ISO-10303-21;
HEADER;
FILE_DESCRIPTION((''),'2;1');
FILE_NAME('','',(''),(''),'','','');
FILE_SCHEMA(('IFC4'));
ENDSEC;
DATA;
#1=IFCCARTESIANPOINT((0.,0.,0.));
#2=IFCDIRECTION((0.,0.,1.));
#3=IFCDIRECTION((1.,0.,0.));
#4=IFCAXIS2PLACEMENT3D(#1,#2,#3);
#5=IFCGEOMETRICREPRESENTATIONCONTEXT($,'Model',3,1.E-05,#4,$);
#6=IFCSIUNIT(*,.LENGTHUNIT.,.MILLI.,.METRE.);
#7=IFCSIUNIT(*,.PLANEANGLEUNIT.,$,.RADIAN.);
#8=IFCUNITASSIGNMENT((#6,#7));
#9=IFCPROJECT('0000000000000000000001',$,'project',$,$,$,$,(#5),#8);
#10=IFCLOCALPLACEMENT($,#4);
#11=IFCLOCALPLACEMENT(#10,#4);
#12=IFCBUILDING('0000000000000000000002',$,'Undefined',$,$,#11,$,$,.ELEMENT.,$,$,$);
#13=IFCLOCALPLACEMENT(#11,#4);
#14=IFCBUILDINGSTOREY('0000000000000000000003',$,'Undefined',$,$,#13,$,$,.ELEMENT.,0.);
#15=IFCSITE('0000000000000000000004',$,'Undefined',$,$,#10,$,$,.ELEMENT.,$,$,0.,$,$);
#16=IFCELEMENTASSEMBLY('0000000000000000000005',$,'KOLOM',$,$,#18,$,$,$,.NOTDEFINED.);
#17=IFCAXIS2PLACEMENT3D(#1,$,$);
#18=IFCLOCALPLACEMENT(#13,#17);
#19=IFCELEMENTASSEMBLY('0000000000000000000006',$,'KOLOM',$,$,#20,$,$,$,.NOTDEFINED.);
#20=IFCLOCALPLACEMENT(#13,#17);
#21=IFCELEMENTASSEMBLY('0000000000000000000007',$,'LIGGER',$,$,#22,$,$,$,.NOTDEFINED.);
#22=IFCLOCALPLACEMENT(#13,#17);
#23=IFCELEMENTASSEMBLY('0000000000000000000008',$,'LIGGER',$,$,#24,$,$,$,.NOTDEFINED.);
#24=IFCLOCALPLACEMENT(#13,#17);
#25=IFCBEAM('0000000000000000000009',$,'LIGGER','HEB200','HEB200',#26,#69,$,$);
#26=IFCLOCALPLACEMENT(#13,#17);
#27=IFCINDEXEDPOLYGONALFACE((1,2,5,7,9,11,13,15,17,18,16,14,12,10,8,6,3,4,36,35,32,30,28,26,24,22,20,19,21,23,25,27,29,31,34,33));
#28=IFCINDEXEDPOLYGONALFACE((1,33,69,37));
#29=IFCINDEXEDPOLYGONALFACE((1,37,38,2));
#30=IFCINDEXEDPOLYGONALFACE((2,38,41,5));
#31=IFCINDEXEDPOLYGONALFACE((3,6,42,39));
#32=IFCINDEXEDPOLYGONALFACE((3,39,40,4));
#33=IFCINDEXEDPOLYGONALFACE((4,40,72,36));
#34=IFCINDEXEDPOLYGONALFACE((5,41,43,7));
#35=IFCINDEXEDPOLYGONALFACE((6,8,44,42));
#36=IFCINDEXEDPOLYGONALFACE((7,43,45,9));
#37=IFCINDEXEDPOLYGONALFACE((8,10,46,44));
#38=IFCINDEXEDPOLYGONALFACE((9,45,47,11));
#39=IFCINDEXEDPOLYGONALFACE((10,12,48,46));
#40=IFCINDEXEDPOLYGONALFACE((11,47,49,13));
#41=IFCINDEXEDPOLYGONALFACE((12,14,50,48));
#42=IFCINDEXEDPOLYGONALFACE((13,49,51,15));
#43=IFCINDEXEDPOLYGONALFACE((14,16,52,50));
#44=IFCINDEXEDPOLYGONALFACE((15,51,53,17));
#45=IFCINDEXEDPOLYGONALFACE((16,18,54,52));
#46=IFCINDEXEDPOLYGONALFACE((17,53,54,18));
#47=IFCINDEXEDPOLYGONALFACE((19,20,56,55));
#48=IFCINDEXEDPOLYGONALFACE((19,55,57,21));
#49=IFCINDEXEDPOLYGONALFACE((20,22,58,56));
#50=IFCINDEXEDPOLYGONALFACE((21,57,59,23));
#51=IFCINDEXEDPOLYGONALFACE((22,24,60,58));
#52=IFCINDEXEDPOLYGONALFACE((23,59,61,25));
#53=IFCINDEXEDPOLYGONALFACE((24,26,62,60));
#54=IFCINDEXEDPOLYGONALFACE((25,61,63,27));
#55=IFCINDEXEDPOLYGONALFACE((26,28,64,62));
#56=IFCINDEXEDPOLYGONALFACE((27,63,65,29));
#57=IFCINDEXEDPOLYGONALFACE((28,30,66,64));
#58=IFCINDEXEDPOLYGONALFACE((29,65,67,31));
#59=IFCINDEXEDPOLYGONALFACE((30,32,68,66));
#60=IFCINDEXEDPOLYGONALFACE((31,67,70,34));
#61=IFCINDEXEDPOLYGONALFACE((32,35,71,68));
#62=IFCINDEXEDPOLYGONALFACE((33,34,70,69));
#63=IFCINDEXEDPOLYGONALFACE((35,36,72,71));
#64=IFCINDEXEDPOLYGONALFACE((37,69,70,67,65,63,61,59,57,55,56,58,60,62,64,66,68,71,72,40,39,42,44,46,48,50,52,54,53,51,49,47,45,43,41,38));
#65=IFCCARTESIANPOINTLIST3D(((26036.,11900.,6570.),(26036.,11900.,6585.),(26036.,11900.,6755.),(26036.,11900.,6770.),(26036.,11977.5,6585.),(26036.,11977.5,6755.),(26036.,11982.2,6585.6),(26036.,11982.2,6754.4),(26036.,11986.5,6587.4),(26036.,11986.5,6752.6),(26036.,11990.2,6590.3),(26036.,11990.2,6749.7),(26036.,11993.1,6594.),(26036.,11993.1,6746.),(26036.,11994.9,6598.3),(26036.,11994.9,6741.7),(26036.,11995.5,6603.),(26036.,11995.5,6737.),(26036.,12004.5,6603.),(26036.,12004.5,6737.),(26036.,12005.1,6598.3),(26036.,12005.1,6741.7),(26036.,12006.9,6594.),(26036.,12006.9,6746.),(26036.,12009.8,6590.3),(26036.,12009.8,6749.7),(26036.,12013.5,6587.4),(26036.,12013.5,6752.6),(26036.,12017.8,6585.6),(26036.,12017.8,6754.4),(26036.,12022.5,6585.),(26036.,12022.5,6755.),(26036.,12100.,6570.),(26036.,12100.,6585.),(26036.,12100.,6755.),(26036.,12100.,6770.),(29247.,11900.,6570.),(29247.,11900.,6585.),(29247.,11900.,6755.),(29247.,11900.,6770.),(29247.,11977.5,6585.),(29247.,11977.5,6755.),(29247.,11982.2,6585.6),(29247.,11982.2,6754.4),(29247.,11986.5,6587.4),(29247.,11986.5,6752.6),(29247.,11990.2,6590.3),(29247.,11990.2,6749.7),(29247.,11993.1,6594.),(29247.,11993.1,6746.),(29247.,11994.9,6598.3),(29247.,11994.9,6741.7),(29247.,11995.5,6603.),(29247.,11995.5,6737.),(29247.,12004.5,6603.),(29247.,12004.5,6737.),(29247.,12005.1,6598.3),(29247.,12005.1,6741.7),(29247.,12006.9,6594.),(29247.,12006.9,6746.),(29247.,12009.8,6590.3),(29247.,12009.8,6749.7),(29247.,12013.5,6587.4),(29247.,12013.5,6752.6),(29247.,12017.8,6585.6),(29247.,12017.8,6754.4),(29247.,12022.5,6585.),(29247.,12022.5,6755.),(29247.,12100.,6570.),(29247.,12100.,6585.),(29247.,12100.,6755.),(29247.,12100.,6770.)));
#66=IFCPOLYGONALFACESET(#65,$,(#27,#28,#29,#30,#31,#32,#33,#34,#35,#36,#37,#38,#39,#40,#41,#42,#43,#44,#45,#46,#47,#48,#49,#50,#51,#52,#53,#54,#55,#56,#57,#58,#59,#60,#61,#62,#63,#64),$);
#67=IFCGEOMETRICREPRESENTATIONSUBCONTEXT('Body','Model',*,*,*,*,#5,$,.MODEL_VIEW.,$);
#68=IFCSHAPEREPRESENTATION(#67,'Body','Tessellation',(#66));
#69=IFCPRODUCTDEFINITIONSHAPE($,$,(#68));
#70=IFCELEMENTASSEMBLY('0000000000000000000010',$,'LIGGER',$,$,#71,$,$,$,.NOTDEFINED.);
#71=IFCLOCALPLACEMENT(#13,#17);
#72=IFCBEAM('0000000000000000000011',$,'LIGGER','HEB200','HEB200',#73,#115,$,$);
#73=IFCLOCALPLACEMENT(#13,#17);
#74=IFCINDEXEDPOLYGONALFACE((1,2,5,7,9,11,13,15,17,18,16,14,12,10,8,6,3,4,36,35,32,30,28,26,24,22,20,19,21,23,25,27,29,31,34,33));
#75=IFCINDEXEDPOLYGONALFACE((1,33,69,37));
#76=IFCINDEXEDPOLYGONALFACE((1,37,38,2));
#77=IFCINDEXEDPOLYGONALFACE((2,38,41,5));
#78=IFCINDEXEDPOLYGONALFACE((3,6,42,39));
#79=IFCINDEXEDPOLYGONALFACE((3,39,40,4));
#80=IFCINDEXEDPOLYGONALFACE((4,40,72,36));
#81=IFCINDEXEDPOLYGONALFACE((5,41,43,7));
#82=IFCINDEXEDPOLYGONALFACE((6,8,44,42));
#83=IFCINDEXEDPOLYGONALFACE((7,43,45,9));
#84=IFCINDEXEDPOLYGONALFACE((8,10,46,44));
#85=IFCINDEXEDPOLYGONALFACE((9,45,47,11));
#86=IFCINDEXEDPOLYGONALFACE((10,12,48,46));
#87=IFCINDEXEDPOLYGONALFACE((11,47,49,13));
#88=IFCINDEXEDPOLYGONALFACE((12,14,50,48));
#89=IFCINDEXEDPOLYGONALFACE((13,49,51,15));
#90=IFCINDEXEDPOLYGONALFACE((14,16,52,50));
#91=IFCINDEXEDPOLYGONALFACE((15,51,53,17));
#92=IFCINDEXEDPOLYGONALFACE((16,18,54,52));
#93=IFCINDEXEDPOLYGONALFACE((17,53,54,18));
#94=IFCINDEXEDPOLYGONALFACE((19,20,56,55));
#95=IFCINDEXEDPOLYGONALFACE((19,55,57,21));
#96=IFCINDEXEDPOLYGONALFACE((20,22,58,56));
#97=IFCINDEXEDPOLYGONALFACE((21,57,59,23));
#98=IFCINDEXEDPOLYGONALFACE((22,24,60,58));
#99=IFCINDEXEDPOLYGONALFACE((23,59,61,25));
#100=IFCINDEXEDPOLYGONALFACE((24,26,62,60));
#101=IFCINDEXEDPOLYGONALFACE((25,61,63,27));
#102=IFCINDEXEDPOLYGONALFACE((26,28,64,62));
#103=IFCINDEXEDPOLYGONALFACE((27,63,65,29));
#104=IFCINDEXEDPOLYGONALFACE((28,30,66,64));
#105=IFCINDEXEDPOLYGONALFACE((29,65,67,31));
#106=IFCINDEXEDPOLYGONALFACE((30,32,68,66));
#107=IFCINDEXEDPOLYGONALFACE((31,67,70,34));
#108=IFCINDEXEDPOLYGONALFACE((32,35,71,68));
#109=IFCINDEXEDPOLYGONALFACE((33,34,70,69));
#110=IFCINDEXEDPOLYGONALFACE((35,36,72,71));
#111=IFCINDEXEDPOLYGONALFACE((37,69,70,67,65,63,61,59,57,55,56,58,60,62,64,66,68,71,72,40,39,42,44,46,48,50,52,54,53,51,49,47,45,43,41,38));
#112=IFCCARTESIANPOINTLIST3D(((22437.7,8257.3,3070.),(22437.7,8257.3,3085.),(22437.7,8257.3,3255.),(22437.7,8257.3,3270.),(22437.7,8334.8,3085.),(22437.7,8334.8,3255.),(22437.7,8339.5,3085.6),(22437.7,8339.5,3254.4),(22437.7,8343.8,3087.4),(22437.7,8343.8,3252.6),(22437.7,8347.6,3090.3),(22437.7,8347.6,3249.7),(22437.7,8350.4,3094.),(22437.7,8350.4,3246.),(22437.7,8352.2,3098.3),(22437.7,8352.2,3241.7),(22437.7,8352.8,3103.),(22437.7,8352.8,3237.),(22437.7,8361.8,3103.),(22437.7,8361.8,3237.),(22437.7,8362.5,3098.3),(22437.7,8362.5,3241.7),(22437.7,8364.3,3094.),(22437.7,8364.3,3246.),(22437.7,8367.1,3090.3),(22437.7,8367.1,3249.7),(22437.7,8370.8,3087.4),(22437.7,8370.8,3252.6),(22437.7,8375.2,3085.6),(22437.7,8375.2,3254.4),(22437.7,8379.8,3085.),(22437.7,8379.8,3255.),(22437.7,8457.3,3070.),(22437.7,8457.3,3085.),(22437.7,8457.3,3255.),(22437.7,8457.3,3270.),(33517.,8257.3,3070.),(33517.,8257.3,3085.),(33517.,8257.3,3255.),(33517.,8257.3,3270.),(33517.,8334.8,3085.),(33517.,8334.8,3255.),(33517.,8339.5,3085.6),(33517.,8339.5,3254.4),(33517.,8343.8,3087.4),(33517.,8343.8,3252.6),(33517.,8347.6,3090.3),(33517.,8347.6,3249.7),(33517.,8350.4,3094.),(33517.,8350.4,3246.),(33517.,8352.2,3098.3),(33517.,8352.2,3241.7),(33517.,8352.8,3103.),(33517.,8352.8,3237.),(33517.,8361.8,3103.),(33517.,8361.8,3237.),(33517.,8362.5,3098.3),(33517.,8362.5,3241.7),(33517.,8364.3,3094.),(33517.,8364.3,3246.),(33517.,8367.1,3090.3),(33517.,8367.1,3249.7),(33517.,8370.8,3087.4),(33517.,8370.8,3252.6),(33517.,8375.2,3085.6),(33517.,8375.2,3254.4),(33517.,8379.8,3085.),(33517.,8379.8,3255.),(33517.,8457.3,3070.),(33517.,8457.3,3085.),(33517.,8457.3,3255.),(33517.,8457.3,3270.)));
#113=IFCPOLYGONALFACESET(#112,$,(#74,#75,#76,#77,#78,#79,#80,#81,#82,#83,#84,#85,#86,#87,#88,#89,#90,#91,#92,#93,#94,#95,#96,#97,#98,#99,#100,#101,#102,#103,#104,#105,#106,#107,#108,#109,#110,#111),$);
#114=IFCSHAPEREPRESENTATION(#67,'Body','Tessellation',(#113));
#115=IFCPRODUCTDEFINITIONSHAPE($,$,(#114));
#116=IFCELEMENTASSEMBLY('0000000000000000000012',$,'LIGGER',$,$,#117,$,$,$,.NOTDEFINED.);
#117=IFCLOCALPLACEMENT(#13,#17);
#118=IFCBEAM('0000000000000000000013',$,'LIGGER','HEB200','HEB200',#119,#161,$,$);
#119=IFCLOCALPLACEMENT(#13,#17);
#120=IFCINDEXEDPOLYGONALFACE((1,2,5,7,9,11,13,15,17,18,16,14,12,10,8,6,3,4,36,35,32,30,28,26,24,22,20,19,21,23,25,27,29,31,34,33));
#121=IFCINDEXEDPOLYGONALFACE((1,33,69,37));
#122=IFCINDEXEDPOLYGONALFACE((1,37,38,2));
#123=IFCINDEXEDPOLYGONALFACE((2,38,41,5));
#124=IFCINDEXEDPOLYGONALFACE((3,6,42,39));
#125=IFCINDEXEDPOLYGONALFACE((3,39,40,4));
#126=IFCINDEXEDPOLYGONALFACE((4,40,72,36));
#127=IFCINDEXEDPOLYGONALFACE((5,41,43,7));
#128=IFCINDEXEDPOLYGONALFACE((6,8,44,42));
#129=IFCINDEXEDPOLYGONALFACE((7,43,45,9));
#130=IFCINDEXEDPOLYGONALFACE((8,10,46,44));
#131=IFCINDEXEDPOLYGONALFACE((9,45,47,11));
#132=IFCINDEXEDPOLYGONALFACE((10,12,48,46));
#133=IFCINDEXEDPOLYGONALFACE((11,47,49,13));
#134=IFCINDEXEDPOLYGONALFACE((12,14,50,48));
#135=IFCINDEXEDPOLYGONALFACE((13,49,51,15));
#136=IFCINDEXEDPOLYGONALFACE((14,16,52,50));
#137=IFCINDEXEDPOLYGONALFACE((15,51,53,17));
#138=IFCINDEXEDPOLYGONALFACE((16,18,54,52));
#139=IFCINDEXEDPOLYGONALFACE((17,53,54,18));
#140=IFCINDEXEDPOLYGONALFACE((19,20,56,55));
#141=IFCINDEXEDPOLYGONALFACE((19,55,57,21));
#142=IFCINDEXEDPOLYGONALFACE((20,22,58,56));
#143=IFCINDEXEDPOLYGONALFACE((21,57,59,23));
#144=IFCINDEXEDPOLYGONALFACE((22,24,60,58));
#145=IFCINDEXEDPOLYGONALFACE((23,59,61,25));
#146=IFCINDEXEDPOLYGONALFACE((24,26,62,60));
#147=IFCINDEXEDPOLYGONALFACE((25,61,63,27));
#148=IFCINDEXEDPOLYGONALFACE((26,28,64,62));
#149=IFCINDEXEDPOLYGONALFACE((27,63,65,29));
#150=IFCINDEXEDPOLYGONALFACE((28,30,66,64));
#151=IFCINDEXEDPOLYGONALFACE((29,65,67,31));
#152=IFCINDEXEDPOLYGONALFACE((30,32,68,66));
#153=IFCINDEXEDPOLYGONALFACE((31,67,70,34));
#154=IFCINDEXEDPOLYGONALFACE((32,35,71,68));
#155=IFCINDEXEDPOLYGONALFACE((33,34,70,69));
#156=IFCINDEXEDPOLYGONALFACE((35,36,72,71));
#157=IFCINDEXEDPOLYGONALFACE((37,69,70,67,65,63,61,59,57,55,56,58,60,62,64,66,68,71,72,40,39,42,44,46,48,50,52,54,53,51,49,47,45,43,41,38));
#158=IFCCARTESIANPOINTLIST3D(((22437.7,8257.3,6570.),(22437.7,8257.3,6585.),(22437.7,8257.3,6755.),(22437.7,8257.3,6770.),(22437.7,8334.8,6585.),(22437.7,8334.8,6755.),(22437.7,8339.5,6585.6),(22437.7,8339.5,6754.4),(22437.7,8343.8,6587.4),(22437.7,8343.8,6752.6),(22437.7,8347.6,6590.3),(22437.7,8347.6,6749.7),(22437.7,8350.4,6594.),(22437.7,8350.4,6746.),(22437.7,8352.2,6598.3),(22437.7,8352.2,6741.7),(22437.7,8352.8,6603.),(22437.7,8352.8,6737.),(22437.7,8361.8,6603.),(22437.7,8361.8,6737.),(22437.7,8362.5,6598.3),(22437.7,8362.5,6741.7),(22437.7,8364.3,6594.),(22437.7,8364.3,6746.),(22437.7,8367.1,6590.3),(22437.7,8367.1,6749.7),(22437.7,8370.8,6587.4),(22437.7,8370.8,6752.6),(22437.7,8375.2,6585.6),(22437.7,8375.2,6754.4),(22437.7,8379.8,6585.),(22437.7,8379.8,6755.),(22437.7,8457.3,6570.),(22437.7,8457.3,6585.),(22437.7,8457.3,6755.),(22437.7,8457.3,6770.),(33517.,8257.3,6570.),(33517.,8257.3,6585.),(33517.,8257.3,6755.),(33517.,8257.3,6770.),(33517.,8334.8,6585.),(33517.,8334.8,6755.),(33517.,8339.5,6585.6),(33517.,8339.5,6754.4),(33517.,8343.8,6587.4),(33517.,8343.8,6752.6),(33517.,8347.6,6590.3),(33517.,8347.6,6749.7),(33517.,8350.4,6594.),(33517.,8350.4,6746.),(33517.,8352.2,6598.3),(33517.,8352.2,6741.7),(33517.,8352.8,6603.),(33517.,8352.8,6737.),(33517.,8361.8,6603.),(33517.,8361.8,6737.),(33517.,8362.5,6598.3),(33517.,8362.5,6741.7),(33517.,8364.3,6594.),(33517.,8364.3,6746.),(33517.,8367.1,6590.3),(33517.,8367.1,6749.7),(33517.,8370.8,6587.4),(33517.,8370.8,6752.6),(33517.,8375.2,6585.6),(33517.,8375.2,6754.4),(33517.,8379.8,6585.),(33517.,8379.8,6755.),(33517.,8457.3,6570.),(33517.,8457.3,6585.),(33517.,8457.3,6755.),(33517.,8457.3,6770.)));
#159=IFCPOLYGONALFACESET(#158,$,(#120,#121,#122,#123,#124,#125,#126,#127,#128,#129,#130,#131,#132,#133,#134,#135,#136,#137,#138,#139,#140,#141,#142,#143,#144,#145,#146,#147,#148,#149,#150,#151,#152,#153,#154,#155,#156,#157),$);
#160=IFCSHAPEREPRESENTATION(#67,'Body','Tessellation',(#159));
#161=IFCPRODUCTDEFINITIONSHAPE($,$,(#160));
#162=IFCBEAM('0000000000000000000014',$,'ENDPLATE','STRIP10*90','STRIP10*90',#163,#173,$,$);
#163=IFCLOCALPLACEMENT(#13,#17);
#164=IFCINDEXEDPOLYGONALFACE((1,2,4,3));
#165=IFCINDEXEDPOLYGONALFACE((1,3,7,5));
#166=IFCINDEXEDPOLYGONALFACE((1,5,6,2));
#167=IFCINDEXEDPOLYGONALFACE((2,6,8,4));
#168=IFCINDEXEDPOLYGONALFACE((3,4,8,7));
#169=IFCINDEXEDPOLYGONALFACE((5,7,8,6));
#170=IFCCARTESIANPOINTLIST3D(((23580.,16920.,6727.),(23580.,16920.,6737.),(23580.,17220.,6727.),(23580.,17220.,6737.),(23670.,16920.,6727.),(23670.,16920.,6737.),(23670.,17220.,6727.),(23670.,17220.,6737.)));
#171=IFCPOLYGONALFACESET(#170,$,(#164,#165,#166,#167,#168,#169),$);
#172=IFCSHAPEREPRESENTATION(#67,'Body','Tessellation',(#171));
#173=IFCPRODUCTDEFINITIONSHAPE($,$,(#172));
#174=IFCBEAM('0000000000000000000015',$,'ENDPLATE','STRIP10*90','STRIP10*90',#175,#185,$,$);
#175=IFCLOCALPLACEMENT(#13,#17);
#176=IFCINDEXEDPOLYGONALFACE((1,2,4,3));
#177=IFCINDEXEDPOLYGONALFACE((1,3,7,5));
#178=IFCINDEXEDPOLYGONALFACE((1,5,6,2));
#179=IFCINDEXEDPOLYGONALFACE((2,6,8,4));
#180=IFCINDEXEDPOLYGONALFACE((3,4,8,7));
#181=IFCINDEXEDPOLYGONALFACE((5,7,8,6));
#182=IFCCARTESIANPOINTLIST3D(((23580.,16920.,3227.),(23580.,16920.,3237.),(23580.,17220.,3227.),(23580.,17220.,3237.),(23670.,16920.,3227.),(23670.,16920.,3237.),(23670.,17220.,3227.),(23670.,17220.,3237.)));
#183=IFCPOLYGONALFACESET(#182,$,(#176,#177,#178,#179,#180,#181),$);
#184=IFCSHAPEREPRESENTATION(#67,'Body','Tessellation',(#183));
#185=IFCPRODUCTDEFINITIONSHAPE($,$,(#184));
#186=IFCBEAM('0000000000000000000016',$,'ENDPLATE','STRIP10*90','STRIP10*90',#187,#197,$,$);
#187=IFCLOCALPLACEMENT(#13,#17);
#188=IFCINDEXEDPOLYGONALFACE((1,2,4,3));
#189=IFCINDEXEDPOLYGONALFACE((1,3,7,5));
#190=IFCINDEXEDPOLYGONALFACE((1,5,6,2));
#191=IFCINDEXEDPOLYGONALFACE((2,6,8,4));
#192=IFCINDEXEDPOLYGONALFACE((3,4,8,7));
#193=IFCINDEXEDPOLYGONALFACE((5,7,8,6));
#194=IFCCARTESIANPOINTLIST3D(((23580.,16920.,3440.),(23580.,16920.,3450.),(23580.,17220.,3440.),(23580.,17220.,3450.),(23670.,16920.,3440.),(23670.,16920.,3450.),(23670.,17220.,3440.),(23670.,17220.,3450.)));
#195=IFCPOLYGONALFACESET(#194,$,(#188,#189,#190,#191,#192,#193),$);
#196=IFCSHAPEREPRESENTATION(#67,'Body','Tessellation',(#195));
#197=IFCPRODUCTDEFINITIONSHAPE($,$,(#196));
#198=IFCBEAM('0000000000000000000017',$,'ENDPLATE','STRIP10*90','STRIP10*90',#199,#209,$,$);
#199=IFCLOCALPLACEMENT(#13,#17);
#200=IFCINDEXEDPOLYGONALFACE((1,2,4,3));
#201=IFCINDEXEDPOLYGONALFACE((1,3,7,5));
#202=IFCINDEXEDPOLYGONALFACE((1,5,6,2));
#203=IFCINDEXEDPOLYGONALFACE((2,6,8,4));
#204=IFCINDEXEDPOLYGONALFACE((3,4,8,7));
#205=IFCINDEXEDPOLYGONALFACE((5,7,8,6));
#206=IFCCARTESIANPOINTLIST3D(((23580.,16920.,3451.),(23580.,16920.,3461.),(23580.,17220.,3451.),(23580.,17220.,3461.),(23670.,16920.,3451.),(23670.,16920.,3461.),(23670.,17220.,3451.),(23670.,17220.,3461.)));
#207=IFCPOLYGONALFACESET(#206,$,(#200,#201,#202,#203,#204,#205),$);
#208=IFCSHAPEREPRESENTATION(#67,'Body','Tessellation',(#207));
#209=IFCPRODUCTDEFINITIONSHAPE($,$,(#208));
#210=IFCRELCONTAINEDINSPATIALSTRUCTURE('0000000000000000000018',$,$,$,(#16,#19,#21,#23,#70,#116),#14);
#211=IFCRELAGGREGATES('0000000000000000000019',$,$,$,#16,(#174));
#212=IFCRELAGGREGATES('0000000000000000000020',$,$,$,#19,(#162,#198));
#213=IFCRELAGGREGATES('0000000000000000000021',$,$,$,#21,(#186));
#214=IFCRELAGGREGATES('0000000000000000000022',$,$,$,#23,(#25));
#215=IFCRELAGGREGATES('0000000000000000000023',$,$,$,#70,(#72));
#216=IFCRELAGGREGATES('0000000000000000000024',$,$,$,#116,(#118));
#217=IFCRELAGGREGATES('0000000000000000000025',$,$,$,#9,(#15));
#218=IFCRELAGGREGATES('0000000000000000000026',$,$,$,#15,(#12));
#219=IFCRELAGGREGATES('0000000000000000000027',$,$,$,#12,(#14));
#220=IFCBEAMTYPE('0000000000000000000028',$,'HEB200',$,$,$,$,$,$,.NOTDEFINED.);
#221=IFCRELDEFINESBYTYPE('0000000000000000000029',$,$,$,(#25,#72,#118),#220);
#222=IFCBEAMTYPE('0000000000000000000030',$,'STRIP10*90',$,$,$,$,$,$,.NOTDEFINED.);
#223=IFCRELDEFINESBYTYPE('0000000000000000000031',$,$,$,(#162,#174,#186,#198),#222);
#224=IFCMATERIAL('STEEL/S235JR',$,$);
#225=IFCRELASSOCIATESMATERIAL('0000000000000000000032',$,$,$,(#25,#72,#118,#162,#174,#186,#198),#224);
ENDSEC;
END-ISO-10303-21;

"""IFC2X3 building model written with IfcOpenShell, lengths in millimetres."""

from ifc_helpers import new_model, si_unit, frame, origin_with_axes, origin_2d_with_axis, place, context, subcontext, project, spatial, rectangle, i_section, extrude, material, type_object, element, aggregate, save


model = new_model("IFC2X3")

# Units and contexts
model_context = context("Model", 3, precision=1e-05, world=origin_with_axes())
body_context = subcontext(model_context, "Body", "Model", "MODEL_VIEW")
ifc_project = project(units=[si_unit("LENGTHUNIT", "METRE", prefix="MILLI"), si_unit("PLANEANGLEUNIT", "RADIAN")], contexts=[model_context])

# Site, building, storey
site_placement = place(None, origin_with_axes())
site = spatial("IfcSite", under=ifc_project, at=site_placement, Name="Undefined", CompositionType="ELEMENT", RefElevation=0.0)
building_placement = place(site_placement, origin_with_axes())
building = spatial("IfcBuilding", under=site, at=building_placement, Name="Undefined", CompositionType="ELEMENT")
storey_placement = place(building_placement, origin_with_axes())
storey = spatial("IfcBuildingStorey", under=building, at=storey_placement, Name="Undefined", CompositionType="ELEMENT", Elevation=0.0)

# Element assemblies
assembly_1_placement = place(storey_placement, origin_with_axes())
assembly_1 = element("IfcElementAssembly", 1, at=assembly_1_placement, inside=storey, Name="KOLOM", PredefinedType="NOTDEFINED")
ifc_material = material(Name="STEEL/S235JR")
assembly_2_placement = place(storey_placement, origin_with_axes())
assembly_2 = element("IfcElementAssembly", 2, at=assembly_2_placement, inside=storey, Name="KOLOM", PredefinedType="NOTDEFINED")

# Element assemblies, beams
assembly_3_placement = place(storey_placement, origin_with_axes())
assembly_3 = element("IfcElementAssembly", 3, at=assembly_3_placement, inside=storey, Name="LIGGER", PredefinedType="NOTDEFINED")
beam_type_1 = type_object("IfcBeamType", Name="HEB200", PredefinedType="NOTDEFINED")
assembly_4_placement = place(storey_placement, origin_with_axes())
assembly_4 = element("IfcElementAssembly", 4, at=assembly_4_placement, inside=storey, Name="LIGGER", PredefinedType="NOTDEFINED")
beam_1_placement = place(assembly_4_placement, frame((25875.0, 12000.0, 6670.0), z_axis=(0.0, 0.0, 1.0), x_axis=(1.0, 0.0, 0.0)))
beam_1 = element("IfcBeam", 5, at=beam_1_placement, type_object=beam_type_1, material=ifc_material, Name="LIGGER", Description="HEB200", ObjectType="HEB200", context=body_context, shape_type="SweptSolid", body=[
    extrude(i_section(OverallWidth=200.0, OverallDepth=200.0, WebThickness=9.0, FlangeThickness=15.0, FilletRadius=18.0, at=origin_2d_with_axis()), frame((3372.0, 0.0, 0.0), z_axis=(-1.0, 0.0, 0.0), x_axis=(0.0, -1.0, 0.0)), (0.0, 0.0, 1.0), 3211.0),
])
assembly_5_placement = place(storey_placement, origin_with_axes())
assembly_5 = element("IfcElementAssembly", 6, at=assembly_5_placement, inside=storey, Name="LIGGER", PredefinedType="NOTDEFINED")
beam_2_placement = place(assembly_5_placement, frame((22427.2, 8357.3, 3170.0), z_axis=(0.0, 0.0, 1.0), x_axis=(1.0, 0.0, 0.0)))
beam_2 = element("IfcBeam", 7, at=beam_2_placement, type_object=beam_type_1, material=ifc_material, Name="LIGGER", Description="HEB200", ObjectType="HEB200", context=body_context, shape_type="SweptSolid", body=[
    extrude(i_section(OverallWidth=200.0, OverallDepth=200.0, WebThickness=9.0, FlangeThickness=15.0, FilletRadius=18.0, at=origin_2d_with_axis()), frame((11089.8, 0.0, 0.0), z_axis=(-1.0, 0.0, 0.0), x_axis=(0.0, -1.0, 0.0)), (0.0, 0.0, 1.0), 11079.3),
])
assembly_6_placement = place(storey_placement, origin_with_axes())
assembly_6 = element("IfcElementAssembly", 8, at=assembly_6_placement, inside=storey, Name="LIGGER", PredefinedType="NOTDEFINED")
beam_3_placement = place(assembly_6_placement, frame((22427.2, 8357.3, 6670.0), z_axis=(0.0, 0.0, 1.0), x_axis=(1.0, 0.0, 0.0)))
beam_3 = element("IfcBeam", 9, at=beam_3_placement, type_object=beam_type_1, material=ifc_material, Name="LIGGER", Description="HEB200", ObjectType="HEB200", context=body_context, shape_type="SweptSolid", body=[
    extrude(i_section(OverallWidth=200.0, OverallDepth=200.0, WebThickness=9.0, FlangeThickness=15.0, FilletRadius=18.0, at=origin_2d_with_axis()), frame((11089.8, 0.0, 0.0), z_axis=(-1.0, 0.0, 0.0), x_axis=(0.0, -1.0, 0.0)), (0.0, 0.0, 1.0), 11079.3),
])

# Beams
beam_type_2 = type_object("IfcBeamType", Name="STRIP10*90", PredefinedType="NOTDEFINED")
beam_4_placement = place(assembly_2_placement, frame((23670.0, 17070.0, 6732.0), z_axis=(0.0, 1.0, 0.0), x_axis=(-1.0, 0.0, 0.0)))
beam_4 = element("IfcBeam", 10, at=beam_4_placement, type_object=beam_type_2, material=ifc_material, Name="ENDPLATE", Description="STRIP10*90", ObjectType="STRIP10*90", context=body_context, shape_type="SweptSolid", body=[
    extrude(rectangle(XDim=10.0, YDim=300.0, at=origin_2d_with_axis()), frame((90.0, 0.0, 0.0), z_axis=(-1.0, 0.0, 0.0), x_axis=(0.0, -1.0, 0.0)), (0.0, 0.0, 1.0), 90.0),
])
beam_5_placement = place(assembly_1_placement, frame((23670.0, 17070.0, 3232.0), z_axis=(0.0, 1.0, 0.0), x_axis=(-1.0, 0.0, 0.0)))
beam_5 = element("IfcBeam", 11, at=beam_5_placement, type_object=beam_type_2, material=ifc_material, Name="ENDPLATE", Description="STRIP10*90", ObjectType="STRIP10*90", context=body_context, shape_type="SweptSolid", body=[
    extrude(rectangle(XDim=10.0, YDim=300.0, at=origin_2d_with_axis()), frame((90.0, 0.0, 0.0), z_axis=(-1.0, 0.0, 0.0), x_axis=(0.0, -1.0, 0.0)), (0.0, 0.0, 1.0), 90.0),
])
aggregate(assembly_1, [beam_5])
beam_6_placement = place(assembly_3_placement, frame((23670.0, 17070.0, 3445.0), z_axis=(0.0, 1.0, 0.0), x_axis=(-1.0, 0.0, 0.0)))
beam_6 = element("IfcBeam", 12, at=beam_6_placement, type_object=beam_type_2, material=ifc_material, Name="ENDPLATE", Description="STRIP10*90", ObjectType="STRIP10*90", context=body_context, shape_type="SweptSolid", body=[
    extrude(rectangle(XDim=10.0, YDim=300.0, at=origin_2d_with_axis()), frame((90.0, 0.0, 0.0), z_axis=(-1.0, 0.0, 0.0), x_axis=(0.0, -1.0, 0.0)), (0.0, 0.0, 1.0), 90.0),
])
beam_7_placement = place(assembly_2_placement, frame((23670.0, 17070.0, 3456.0), z_axis=(0.0, -1.0, 0.0), x_axis=(-1.0, 0.0, 0.0)))
beam_7 = element("IfcBeam", 13, at=beam_7_placement, type_object=beam_type_2, material=ifc_material, Name="ENDPLATE", Description="STRIP10*90", ObjectType="STRIP10*90", context=body_context, shape_type="SweptSolid", body=[
    extrude(rectangle(XDim=10.0, YDim=300.0, at=origin_2d_with_axis()), frame((90.0, 0.0, 0.0), z_axis=(-1.0, 0.0, 0.0), x_axis=(0.0, -1.0, 0.0)), (0.0, 0.0, 1.0), 90.0),
])
aggregate(assembly_2, [beam_4, beam_7])
aggregate(assembly_3, [beam_6])
aggregate(assembly_4, [beam_1])
aggregate(assembly_5, [beam_2])
aggregate(assembly_6, [beam_3])

save(model, "model.ifc")
